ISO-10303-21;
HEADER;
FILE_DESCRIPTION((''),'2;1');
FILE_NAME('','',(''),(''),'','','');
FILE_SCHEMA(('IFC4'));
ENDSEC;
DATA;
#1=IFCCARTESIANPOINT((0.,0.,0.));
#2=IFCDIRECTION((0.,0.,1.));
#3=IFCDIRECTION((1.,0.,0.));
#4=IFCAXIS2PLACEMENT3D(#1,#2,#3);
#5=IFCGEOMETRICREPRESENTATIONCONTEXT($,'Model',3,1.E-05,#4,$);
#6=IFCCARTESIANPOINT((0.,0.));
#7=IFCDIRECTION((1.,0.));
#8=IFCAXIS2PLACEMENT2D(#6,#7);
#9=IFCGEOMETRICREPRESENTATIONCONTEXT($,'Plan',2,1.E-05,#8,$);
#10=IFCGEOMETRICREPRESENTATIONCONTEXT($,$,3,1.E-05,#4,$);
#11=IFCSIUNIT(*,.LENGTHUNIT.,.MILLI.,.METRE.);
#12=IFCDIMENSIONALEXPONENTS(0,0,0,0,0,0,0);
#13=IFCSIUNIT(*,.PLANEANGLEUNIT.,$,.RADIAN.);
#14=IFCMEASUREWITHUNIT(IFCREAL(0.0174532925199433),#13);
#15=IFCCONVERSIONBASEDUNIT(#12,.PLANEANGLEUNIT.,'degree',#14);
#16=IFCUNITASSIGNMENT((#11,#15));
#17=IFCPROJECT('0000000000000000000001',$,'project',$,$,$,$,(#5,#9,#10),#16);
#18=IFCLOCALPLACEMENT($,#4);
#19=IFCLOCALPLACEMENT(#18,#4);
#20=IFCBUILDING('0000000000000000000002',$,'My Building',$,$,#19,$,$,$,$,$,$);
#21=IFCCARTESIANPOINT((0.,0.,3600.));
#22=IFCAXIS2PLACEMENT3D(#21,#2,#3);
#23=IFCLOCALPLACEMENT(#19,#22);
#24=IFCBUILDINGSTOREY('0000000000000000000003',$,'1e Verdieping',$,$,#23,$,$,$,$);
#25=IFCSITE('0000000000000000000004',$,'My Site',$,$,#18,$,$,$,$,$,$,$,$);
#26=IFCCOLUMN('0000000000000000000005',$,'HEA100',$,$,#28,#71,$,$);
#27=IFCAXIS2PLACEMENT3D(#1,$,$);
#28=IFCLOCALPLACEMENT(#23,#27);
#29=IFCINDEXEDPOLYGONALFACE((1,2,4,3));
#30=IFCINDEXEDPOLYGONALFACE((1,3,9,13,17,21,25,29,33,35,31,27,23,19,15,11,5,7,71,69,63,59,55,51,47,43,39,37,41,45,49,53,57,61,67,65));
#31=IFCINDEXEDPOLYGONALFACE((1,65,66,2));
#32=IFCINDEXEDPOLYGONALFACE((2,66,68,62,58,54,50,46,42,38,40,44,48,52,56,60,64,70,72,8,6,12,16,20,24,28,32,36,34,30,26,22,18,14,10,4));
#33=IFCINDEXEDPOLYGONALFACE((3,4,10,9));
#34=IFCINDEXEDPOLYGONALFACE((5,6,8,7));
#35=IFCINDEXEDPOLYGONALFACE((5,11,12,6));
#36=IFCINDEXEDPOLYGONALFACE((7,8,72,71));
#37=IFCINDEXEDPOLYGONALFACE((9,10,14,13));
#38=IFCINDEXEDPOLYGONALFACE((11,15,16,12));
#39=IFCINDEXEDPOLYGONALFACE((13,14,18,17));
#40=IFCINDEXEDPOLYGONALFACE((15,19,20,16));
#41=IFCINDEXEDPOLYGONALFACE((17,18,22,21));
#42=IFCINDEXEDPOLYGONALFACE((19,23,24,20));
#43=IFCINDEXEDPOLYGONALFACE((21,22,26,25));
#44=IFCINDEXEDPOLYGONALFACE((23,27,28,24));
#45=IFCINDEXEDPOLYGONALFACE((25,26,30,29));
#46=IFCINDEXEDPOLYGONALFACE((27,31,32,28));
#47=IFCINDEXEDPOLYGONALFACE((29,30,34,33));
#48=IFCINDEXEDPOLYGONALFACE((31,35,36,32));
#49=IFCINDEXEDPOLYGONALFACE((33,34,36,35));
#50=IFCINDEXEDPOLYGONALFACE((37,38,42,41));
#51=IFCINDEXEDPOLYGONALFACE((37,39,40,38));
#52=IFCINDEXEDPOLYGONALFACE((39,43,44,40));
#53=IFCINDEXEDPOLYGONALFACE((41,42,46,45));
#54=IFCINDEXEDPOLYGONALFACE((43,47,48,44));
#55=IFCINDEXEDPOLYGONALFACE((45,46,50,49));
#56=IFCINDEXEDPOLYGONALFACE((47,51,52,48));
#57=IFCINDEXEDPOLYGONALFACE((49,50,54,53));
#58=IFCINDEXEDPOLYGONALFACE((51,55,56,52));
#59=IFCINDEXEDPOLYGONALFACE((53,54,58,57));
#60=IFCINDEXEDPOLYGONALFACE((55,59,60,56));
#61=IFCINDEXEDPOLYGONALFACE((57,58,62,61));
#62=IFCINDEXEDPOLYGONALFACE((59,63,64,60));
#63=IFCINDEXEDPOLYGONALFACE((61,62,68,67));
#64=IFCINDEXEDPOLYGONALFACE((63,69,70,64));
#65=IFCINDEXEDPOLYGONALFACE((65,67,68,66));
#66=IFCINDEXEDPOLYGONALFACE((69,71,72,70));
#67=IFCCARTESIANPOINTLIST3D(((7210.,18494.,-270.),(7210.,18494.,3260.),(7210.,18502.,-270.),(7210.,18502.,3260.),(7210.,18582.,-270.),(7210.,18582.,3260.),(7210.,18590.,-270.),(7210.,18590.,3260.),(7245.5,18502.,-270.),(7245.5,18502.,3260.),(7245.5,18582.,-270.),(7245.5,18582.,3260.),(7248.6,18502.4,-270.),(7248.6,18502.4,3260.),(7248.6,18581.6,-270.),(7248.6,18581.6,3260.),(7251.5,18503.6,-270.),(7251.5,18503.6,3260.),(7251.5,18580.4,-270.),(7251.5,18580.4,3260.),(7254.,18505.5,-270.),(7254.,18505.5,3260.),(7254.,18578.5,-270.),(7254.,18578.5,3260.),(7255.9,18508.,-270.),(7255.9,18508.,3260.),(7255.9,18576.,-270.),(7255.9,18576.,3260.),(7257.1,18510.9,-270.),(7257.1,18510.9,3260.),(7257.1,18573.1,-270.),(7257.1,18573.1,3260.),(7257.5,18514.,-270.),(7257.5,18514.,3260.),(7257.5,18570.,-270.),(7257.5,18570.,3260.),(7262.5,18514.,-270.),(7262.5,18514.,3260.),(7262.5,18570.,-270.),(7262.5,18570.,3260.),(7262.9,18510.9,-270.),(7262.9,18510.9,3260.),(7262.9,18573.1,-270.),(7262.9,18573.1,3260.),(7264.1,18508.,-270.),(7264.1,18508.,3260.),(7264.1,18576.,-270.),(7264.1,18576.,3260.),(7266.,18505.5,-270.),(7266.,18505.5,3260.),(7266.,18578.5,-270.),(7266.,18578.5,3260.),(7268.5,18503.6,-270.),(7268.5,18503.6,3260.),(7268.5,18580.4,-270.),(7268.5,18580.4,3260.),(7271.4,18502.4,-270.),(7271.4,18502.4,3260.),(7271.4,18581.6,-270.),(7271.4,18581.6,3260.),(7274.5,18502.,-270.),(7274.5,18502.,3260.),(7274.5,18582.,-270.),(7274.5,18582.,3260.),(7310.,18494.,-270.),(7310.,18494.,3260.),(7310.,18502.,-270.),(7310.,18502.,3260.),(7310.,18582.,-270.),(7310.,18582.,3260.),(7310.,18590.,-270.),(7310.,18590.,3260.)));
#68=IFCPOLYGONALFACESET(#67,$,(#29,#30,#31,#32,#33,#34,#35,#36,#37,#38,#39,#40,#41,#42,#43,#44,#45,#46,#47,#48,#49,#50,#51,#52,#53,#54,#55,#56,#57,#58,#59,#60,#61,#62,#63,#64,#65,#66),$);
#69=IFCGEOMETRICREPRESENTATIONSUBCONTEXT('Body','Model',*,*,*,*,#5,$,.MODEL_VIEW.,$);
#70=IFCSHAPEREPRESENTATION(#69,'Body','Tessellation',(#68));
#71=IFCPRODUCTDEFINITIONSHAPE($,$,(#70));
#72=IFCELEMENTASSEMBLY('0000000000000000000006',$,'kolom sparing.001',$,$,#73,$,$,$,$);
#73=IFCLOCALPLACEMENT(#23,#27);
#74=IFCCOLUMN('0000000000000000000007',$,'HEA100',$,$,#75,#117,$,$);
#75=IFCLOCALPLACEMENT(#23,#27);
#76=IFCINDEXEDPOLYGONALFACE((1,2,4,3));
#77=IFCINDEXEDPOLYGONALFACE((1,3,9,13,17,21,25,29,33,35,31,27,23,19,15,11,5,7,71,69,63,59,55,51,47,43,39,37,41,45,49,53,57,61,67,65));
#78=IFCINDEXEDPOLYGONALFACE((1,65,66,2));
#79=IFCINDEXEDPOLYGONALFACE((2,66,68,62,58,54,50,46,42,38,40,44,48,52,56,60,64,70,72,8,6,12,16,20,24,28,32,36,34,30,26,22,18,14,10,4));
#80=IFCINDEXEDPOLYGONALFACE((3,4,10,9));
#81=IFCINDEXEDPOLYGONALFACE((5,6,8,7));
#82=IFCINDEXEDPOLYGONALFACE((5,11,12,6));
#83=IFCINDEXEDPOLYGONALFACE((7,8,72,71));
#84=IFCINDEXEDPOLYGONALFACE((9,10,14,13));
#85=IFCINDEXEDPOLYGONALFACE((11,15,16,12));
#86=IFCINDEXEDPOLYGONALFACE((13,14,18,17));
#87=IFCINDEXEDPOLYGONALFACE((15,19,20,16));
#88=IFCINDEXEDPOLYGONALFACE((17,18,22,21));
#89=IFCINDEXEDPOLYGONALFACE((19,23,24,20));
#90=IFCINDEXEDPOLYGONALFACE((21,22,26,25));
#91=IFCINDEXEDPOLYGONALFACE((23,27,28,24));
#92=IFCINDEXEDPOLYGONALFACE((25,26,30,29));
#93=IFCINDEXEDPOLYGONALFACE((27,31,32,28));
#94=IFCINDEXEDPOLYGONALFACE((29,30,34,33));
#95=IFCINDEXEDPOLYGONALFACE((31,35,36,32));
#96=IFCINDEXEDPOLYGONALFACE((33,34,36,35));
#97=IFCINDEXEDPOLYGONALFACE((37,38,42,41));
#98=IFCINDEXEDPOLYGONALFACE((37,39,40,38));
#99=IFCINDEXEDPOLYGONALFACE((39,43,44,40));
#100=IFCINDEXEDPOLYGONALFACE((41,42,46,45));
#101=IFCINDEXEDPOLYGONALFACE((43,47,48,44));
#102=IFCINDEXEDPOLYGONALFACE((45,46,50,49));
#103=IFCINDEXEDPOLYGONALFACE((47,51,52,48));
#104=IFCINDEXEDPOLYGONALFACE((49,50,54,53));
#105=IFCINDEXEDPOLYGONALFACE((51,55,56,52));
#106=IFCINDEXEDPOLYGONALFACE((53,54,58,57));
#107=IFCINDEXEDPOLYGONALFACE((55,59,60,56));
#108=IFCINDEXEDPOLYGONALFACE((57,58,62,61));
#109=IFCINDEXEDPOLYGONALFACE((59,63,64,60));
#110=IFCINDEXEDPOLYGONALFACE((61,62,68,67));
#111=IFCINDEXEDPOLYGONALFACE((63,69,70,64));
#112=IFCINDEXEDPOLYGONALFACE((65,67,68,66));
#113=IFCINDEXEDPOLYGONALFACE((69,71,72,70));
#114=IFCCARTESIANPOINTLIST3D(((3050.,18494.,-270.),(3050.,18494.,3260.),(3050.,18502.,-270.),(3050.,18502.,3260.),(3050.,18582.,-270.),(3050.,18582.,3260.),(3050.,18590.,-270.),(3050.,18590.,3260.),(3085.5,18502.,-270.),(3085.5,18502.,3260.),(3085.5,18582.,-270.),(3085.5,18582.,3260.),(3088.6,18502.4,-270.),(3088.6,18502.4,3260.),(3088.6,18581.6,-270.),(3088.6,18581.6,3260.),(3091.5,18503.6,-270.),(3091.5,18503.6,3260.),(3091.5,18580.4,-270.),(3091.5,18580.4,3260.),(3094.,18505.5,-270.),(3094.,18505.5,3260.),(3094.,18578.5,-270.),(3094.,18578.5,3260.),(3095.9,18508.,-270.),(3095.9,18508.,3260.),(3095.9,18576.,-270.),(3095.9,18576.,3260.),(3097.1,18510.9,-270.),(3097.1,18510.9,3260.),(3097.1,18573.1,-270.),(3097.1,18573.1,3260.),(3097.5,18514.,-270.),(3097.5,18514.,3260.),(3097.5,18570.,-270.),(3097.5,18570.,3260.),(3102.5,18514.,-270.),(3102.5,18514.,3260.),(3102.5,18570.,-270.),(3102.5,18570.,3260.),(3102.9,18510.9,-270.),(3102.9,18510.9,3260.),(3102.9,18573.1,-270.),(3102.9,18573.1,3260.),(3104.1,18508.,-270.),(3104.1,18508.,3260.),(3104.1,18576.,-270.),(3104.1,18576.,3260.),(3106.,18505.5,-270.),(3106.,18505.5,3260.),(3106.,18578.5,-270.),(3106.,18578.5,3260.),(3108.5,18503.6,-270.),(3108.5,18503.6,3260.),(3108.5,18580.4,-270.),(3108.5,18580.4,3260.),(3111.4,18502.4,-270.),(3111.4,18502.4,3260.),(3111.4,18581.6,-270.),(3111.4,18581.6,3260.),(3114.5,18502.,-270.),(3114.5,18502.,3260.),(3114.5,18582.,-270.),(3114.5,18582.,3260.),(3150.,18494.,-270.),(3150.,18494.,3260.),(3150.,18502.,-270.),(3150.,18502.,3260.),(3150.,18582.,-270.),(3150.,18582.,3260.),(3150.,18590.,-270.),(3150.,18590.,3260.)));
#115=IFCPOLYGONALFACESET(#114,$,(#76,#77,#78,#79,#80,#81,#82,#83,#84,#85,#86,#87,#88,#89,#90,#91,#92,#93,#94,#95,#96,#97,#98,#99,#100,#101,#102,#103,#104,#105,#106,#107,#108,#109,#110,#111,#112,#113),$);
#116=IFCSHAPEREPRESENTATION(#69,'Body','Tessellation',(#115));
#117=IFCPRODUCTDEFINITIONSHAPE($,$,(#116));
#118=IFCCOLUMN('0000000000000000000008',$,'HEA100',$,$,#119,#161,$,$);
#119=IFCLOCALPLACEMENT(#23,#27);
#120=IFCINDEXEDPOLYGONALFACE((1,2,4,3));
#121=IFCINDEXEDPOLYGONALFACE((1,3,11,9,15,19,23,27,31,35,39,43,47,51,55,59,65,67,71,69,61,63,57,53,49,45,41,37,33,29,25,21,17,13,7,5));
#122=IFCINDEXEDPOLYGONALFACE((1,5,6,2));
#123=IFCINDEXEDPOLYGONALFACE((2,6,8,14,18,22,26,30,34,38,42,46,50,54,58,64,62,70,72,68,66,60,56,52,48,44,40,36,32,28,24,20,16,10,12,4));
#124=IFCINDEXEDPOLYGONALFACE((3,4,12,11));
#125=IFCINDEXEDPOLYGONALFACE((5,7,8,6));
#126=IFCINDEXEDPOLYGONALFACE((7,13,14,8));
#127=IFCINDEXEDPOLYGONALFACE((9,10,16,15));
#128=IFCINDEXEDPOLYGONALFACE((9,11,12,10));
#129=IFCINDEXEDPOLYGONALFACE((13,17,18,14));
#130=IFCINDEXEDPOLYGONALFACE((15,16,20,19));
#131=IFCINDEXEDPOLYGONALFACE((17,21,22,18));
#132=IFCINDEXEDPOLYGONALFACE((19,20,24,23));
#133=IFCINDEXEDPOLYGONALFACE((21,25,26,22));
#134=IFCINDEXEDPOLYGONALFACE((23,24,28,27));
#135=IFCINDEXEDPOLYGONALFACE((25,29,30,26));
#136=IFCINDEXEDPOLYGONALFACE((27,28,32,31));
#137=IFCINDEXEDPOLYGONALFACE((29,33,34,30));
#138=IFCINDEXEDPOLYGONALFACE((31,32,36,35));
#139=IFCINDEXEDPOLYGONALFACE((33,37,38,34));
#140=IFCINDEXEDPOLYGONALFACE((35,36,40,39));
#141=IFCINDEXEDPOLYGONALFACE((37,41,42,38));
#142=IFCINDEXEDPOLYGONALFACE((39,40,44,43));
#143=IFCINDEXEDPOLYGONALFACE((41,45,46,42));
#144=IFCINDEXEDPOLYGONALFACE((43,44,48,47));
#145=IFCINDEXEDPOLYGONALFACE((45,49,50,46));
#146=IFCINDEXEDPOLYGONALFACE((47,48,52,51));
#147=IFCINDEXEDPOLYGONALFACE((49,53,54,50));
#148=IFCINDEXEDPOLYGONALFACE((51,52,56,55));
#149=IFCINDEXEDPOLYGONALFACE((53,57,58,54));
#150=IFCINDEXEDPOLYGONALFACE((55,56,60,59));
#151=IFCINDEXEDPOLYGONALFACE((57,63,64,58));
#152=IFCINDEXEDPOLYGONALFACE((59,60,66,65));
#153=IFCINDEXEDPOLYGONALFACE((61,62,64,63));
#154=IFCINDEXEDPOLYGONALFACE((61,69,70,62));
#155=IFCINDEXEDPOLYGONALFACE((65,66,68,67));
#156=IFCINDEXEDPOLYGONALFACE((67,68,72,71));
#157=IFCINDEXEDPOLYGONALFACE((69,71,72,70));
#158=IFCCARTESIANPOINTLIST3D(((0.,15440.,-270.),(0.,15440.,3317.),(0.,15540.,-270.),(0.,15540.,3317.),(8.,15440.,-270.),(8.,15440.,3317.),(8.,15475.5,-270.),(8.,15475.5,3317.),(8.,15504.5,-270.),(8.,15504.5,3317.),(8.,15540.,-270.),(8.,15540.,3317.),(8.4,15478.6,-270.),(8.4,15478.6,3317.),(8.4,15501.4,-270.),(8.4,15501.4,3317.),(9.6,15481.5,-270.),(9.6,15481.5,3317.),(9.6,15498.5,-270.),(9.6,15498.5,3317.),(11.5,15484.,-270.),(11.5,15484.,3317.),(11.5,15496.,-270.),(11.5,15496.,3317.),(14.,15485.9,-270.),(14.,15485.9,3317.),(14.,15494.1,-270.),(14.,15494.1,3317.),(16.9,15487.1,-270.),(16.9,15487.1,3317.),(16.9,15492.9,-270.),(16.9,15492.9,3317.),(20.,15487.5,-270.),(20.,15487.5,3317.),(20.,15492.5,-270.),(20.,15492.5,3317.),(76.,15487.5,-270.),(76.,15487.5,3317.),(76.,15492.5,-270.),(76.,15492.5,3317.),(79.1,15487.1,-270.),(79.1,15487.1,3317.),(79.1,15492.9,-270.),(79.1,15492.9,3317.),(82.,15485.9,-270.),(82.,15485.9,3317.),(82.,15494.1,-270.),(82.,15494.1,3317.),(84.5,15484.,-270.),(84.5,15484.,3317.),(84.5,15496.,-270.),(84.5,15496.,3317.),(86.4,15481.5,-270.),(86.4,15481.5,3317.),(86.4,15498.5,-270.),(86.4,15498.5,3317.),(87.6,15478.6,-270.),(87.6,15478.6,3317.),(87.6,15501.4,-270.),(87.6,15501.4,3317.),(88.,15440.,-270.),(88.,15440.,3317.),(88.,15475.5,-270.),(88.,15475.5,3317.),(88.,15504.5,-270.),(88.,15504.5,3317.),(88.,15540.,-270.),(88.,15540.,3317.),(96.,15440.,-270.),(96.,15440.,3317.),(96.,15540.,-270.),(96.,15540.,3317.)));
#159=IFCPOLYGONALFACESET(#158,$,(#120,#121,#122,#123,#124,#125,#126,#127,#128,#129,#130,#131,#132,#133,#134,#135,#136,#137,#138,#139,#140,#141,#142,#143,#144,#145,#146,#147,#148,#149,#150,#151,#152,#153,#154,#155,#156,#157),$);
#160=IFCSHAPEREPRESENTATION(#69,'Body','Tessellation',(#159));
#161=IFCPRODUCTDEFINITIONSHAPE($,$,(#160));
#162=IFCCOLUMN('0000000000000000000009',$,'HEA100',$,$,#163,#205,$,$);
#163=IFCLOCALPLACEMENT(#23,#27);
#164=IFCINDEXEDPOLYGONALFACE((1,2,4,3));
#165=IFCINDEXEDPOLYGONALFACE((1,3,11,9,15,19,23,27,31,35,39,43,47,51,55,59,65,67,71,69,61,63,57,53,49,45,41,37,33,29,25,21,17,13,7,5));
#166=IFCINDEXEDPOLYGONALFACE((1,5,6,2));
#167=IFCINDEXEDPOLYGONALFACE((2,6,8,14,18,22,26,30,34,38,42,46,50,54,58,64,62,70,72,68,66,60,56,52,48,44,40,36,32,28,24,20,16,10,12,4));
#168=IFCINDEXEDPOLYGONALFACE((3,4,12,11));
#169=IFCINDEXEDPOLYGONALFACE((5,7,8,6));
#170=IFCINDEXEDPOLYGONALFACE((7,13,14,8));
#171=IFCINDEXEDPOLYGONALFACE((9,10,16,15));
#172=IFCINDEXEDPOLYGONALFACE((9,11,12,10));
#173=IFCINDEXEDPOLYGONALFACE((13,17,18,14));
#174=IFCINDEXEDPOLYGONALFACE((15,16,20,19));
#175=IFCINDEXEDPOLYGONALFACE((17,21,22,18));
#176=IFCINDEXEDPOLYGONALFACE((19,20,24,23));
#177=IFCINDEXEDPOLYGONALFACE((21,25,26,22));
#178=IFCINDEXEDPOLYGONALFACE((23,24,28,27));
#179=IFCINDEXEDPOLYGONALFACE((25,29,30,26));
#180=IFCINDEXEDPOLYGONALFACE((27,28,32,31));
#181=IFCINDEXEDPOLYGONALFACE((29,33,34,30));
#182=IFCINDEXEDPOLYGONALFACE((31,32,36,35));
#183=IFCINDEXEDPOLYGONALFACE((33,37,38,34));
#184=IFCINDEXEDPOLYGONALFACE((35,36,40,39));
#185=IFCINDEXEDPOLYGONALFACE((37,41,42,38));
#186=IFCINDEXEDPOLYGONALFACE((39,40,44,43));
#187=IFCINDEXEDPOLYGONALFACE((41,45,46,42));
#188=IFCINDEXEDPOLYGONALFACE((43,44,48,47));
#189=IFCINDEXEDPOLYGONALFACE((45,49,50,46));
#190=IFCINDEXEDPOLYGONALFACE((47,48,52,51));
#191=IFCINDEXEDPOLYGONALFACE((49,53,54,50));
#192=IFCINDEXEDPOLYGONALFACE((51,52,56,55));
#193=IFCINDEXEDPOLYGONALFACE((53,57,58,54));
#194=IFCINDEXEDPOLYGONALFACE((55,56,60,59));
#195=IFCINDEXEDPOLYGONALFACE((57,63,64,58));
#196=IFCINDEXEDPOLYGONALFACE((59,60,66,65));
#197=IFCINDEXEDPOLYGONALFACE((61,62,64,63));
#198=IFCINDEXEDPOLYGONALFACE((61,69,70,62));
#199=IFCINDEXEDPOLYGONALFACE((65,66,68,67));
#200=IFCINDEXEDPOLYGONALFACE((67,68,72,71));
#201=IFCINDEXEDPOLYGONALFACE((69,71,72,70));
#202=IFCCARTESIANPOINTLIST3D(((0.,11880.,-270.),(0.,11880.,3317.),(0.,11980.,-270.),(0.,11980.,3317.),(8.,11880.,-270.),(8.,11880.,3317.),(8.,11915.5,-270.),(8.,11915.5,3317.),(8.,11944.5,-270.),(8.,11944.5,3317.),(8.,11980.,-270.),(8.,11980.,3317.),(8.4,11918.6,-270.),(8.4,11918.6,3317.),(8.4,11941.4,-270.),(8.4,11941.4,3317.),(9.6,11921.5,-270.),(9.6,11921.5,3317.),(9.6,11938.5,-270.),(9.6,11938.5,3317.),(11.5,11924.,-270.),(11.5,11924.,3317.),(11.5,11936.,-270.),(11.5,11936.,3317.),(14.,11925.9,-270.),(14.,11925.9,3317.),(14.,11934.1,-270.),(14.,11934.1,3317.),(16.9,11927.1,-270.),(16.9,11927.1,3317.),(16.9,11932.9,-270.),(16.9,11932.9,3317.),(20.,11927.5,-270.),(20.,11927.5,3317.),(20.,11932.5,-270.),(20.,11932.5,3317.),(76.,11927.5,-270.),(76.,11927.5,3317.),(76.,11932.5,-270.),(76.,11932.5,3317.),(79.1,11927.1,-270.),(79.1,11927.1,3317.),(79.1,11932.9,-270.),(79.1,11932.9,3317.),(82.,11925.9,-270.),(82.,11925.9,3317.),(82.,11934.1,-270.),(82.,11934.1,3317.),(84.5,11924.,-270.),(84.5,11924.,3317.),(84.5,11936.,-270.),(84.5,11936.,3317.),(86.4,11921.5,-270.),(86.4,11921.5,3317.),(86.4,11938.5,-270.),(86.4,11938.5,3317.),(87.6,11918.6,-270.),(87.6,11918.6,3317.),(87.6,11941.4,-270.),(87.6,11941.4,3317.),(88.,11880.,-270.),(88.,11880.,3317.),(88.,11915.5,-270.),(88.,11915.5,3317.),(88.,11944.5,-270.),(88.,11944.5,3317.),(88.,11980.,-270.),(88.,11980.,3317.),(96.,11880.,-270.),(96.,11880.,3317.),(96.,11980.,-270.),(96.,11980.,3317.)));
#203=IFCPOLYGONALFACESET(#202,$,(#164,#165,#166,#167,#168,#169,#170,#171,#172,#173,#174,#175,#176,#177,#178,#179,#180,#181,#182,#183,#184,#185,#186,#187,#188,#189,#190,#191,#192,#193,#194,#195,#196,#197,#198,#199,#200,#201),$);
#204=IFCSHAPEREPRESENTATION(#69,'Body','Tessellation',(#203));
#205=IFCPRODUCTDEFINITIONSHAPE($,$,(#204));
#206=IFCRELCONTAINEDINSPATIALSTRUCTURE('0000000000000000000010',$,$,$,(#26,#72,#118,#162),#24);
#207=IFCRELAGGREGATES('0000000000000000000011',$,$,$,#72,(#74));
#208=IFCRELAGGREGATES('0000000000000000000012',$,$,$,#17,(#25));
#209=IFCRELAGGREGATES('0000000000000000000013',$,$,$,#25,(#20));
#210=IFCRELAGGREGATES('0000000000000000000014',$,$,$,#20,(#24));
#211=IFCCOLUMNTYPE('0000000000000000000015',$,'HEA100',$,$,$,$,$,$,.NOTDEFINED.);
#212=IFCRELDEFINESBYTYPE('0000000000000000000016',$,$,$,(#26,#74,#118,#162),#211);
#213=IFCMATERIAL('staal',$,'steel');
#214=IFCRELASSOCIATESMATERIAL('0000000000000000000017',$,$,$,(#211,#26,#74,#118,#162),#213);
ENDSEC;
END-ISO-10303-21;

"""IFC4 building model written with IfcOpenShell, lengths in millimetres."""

from ifc_helpers import new_model, entity, si_unit, converted_unit, frame, origin_with_axes, origin_2d_with_axis, place, context, subcontext, project, spatial, i_section, extrude, material, material_profile, profile_set, profile_usage, type_object, element, aggregate, save


model = new_model("IFC4")

# Units and contexts
model_context = context("Model", 3, precision=1e-05, world=origin_with_axes())
plan_context = context("Plan", 2, precision=1e-05, world=origin_2d_with_axis())
context_of_model = context(None, 3, precision=1e-05, world=origin_with_axes())
body_context = subcontext(model_context, "Body", "Model", "MODEL_VIEW")
ifc_project = project(units=[si_unit("LENGTHUNIT", "METRE", prefix="MILLI"), converted_unit("PLANEANGLEUNIT", "degree", entity("IfcReal", 0.0174532925199433), si_unit("PLANEANGLEUNIT", "RADIAN"), dimensions=[0, 0, 0, 0, 0, 0, 0])], contexts=[model_context, plan_context, context_of_model])

# Site, building, storey
site_placement = place(None, origin_with_axes())
site = spatial("IfcSite", under=ifc_project, at=site_placement, Name="My Site")
building_placement = place(site_placement, origin_with_axes())
building = spatial("IfcBuilding", under=site, at=building_placement, Name="My Building")
storey_placement = place(building_placement, frame((0.0, 0.0, 3600.0), z_axis=(0.0, 0.0, 1.0), x_axis=(1.0, 0.0, 0.0)))
storey = spatial("IfcBuildingStorey", under=building, at=storey_placement, Name="1e Verdieping")

# Column
ifc_material = material(Name="staal", Category="steel")
ifc_material_profile_1 = material_profile(ifc_material, i_section(OverallWidth=100.0, OverallDepth=96.0, WebThickness=5.0, FlangeThickness=8.0, FilletRadius=12.0))
ifc_profile_set_1 = profile_set([ifc_material_profile_1], Name="HEA100")
column_type_1 = type_object("IfcColumnType", Name="HEA100", PredefinedType="NOTDEFINED", material=ifc_profile_set_1)
ifc_profile_usage_1 = profile_usage(ifc_profile_set_1)
column_1_placement = place(storey_placement, frame((7260.0, 18542.0, -270.0), z_axis=(0.0, 0.0, 1.0), x_axis=(1.0, 0.0, 0.0)))
element("IfcColumn", 1, at=column_1_placement, inside=storey, type_object=column_type_1, material=ifc_profile_usage_1, Name="HEA100", context=body_context, shape_type="SweptSolid", body=[
    extrude(i_section(OverallWidth=100.0, OverallDepth=96.0, WebThickness=5.0, FlangeThickness=8.0, FilletRadius=12.0), origin_with_axes(), (0.0, 0.0, 1.0), 3530.0),
])

# Element assembly, column
assembly_placement = place(storey_placement, frame((3030.0, 18494.0, -270.0), z_axis=(0.0, 0.0, 1.0), x_axis=(1.0, 0.0, 0.0)))
assembly = element("IfcElementAssembly", 2, at=assembly_placement, inside=storey, Name="kolom sparing.001")
ifc_profile_usage_2 = profile_usage(ifc_profile_set_1)
column_2_placement = place(assembly_placement, frame((70.0, 48.0, 0.0), z_axis=(0.0, 0.0, 1.0), x_axis=(1.0, 0.0, 0.0)))
column_2 = element("IfcColumn", 3, at=column_2_placement, type_object=column_type_1, material=ifc_profile_usage_2, Name="HEA100", context=body_context, shape_type="SweptSolid", body=[
    extrude(i_section(OverallWidth=100.0, OverallDepth=96.0, WebThickness=5.0, FlangeThickness=8.0, FilletRadius=12.0), origin_with_axes(), (0.0, 0.0, 1.0), 3530.0),
])
aggregate(assembly, [column_2])

# Columns
ifc_profile_usage_3 = profile_usage(ifc_profile_set_1)
column_3_placement = place(storey_placement, frame((48.0, 15490.0, -270.0), z_axis=(0.0, 0.0, 1.0), x_axis=(0.0, 1.0, 0.0)))
element("IfcColumn", 4, at=column_3_placement, inside=storey, type_object=column_type_1, material=ifc_profile_usage_3, Name="HEA100", context=body_context, shape_type="SweptSolid", body=[
    extrude(i_section(OverallWidth=100.0, OverallDepth=96.0, WebThickness=5.0, FlangeThickness=8.0, FilletRadius=12.0), origin_with_axes(), (0.0, 0.0, 1.0), 3587.0),
])
ifc_profile_usage_4 = profile_usage(ifc_profile_set_1)
column_4_placement = place(storey_placement, frame((48.0, 11930.0, -270.0), z_axis=(0.0, 0.0, 1.0), x_axis=(0.0, 1.0, 0.0)))
element("IfcColumn", 5, at=column_4_placement, inside=storey, type_object=column_type_1, material=ifc_profile_usage_4, Name="HEA100", context=body_context, shape_type="SweptSolid", body=[
    extrude(i_section(OverallWidth=100.0, OverallDepth=96.0, WebThickness=5.0, FlangeThickness=8.0, FilletRadius=12.0), origin_with_axes(), (0.0, 0.0, 1.0), 3587.0),
])

save(model, "model.ifc")
